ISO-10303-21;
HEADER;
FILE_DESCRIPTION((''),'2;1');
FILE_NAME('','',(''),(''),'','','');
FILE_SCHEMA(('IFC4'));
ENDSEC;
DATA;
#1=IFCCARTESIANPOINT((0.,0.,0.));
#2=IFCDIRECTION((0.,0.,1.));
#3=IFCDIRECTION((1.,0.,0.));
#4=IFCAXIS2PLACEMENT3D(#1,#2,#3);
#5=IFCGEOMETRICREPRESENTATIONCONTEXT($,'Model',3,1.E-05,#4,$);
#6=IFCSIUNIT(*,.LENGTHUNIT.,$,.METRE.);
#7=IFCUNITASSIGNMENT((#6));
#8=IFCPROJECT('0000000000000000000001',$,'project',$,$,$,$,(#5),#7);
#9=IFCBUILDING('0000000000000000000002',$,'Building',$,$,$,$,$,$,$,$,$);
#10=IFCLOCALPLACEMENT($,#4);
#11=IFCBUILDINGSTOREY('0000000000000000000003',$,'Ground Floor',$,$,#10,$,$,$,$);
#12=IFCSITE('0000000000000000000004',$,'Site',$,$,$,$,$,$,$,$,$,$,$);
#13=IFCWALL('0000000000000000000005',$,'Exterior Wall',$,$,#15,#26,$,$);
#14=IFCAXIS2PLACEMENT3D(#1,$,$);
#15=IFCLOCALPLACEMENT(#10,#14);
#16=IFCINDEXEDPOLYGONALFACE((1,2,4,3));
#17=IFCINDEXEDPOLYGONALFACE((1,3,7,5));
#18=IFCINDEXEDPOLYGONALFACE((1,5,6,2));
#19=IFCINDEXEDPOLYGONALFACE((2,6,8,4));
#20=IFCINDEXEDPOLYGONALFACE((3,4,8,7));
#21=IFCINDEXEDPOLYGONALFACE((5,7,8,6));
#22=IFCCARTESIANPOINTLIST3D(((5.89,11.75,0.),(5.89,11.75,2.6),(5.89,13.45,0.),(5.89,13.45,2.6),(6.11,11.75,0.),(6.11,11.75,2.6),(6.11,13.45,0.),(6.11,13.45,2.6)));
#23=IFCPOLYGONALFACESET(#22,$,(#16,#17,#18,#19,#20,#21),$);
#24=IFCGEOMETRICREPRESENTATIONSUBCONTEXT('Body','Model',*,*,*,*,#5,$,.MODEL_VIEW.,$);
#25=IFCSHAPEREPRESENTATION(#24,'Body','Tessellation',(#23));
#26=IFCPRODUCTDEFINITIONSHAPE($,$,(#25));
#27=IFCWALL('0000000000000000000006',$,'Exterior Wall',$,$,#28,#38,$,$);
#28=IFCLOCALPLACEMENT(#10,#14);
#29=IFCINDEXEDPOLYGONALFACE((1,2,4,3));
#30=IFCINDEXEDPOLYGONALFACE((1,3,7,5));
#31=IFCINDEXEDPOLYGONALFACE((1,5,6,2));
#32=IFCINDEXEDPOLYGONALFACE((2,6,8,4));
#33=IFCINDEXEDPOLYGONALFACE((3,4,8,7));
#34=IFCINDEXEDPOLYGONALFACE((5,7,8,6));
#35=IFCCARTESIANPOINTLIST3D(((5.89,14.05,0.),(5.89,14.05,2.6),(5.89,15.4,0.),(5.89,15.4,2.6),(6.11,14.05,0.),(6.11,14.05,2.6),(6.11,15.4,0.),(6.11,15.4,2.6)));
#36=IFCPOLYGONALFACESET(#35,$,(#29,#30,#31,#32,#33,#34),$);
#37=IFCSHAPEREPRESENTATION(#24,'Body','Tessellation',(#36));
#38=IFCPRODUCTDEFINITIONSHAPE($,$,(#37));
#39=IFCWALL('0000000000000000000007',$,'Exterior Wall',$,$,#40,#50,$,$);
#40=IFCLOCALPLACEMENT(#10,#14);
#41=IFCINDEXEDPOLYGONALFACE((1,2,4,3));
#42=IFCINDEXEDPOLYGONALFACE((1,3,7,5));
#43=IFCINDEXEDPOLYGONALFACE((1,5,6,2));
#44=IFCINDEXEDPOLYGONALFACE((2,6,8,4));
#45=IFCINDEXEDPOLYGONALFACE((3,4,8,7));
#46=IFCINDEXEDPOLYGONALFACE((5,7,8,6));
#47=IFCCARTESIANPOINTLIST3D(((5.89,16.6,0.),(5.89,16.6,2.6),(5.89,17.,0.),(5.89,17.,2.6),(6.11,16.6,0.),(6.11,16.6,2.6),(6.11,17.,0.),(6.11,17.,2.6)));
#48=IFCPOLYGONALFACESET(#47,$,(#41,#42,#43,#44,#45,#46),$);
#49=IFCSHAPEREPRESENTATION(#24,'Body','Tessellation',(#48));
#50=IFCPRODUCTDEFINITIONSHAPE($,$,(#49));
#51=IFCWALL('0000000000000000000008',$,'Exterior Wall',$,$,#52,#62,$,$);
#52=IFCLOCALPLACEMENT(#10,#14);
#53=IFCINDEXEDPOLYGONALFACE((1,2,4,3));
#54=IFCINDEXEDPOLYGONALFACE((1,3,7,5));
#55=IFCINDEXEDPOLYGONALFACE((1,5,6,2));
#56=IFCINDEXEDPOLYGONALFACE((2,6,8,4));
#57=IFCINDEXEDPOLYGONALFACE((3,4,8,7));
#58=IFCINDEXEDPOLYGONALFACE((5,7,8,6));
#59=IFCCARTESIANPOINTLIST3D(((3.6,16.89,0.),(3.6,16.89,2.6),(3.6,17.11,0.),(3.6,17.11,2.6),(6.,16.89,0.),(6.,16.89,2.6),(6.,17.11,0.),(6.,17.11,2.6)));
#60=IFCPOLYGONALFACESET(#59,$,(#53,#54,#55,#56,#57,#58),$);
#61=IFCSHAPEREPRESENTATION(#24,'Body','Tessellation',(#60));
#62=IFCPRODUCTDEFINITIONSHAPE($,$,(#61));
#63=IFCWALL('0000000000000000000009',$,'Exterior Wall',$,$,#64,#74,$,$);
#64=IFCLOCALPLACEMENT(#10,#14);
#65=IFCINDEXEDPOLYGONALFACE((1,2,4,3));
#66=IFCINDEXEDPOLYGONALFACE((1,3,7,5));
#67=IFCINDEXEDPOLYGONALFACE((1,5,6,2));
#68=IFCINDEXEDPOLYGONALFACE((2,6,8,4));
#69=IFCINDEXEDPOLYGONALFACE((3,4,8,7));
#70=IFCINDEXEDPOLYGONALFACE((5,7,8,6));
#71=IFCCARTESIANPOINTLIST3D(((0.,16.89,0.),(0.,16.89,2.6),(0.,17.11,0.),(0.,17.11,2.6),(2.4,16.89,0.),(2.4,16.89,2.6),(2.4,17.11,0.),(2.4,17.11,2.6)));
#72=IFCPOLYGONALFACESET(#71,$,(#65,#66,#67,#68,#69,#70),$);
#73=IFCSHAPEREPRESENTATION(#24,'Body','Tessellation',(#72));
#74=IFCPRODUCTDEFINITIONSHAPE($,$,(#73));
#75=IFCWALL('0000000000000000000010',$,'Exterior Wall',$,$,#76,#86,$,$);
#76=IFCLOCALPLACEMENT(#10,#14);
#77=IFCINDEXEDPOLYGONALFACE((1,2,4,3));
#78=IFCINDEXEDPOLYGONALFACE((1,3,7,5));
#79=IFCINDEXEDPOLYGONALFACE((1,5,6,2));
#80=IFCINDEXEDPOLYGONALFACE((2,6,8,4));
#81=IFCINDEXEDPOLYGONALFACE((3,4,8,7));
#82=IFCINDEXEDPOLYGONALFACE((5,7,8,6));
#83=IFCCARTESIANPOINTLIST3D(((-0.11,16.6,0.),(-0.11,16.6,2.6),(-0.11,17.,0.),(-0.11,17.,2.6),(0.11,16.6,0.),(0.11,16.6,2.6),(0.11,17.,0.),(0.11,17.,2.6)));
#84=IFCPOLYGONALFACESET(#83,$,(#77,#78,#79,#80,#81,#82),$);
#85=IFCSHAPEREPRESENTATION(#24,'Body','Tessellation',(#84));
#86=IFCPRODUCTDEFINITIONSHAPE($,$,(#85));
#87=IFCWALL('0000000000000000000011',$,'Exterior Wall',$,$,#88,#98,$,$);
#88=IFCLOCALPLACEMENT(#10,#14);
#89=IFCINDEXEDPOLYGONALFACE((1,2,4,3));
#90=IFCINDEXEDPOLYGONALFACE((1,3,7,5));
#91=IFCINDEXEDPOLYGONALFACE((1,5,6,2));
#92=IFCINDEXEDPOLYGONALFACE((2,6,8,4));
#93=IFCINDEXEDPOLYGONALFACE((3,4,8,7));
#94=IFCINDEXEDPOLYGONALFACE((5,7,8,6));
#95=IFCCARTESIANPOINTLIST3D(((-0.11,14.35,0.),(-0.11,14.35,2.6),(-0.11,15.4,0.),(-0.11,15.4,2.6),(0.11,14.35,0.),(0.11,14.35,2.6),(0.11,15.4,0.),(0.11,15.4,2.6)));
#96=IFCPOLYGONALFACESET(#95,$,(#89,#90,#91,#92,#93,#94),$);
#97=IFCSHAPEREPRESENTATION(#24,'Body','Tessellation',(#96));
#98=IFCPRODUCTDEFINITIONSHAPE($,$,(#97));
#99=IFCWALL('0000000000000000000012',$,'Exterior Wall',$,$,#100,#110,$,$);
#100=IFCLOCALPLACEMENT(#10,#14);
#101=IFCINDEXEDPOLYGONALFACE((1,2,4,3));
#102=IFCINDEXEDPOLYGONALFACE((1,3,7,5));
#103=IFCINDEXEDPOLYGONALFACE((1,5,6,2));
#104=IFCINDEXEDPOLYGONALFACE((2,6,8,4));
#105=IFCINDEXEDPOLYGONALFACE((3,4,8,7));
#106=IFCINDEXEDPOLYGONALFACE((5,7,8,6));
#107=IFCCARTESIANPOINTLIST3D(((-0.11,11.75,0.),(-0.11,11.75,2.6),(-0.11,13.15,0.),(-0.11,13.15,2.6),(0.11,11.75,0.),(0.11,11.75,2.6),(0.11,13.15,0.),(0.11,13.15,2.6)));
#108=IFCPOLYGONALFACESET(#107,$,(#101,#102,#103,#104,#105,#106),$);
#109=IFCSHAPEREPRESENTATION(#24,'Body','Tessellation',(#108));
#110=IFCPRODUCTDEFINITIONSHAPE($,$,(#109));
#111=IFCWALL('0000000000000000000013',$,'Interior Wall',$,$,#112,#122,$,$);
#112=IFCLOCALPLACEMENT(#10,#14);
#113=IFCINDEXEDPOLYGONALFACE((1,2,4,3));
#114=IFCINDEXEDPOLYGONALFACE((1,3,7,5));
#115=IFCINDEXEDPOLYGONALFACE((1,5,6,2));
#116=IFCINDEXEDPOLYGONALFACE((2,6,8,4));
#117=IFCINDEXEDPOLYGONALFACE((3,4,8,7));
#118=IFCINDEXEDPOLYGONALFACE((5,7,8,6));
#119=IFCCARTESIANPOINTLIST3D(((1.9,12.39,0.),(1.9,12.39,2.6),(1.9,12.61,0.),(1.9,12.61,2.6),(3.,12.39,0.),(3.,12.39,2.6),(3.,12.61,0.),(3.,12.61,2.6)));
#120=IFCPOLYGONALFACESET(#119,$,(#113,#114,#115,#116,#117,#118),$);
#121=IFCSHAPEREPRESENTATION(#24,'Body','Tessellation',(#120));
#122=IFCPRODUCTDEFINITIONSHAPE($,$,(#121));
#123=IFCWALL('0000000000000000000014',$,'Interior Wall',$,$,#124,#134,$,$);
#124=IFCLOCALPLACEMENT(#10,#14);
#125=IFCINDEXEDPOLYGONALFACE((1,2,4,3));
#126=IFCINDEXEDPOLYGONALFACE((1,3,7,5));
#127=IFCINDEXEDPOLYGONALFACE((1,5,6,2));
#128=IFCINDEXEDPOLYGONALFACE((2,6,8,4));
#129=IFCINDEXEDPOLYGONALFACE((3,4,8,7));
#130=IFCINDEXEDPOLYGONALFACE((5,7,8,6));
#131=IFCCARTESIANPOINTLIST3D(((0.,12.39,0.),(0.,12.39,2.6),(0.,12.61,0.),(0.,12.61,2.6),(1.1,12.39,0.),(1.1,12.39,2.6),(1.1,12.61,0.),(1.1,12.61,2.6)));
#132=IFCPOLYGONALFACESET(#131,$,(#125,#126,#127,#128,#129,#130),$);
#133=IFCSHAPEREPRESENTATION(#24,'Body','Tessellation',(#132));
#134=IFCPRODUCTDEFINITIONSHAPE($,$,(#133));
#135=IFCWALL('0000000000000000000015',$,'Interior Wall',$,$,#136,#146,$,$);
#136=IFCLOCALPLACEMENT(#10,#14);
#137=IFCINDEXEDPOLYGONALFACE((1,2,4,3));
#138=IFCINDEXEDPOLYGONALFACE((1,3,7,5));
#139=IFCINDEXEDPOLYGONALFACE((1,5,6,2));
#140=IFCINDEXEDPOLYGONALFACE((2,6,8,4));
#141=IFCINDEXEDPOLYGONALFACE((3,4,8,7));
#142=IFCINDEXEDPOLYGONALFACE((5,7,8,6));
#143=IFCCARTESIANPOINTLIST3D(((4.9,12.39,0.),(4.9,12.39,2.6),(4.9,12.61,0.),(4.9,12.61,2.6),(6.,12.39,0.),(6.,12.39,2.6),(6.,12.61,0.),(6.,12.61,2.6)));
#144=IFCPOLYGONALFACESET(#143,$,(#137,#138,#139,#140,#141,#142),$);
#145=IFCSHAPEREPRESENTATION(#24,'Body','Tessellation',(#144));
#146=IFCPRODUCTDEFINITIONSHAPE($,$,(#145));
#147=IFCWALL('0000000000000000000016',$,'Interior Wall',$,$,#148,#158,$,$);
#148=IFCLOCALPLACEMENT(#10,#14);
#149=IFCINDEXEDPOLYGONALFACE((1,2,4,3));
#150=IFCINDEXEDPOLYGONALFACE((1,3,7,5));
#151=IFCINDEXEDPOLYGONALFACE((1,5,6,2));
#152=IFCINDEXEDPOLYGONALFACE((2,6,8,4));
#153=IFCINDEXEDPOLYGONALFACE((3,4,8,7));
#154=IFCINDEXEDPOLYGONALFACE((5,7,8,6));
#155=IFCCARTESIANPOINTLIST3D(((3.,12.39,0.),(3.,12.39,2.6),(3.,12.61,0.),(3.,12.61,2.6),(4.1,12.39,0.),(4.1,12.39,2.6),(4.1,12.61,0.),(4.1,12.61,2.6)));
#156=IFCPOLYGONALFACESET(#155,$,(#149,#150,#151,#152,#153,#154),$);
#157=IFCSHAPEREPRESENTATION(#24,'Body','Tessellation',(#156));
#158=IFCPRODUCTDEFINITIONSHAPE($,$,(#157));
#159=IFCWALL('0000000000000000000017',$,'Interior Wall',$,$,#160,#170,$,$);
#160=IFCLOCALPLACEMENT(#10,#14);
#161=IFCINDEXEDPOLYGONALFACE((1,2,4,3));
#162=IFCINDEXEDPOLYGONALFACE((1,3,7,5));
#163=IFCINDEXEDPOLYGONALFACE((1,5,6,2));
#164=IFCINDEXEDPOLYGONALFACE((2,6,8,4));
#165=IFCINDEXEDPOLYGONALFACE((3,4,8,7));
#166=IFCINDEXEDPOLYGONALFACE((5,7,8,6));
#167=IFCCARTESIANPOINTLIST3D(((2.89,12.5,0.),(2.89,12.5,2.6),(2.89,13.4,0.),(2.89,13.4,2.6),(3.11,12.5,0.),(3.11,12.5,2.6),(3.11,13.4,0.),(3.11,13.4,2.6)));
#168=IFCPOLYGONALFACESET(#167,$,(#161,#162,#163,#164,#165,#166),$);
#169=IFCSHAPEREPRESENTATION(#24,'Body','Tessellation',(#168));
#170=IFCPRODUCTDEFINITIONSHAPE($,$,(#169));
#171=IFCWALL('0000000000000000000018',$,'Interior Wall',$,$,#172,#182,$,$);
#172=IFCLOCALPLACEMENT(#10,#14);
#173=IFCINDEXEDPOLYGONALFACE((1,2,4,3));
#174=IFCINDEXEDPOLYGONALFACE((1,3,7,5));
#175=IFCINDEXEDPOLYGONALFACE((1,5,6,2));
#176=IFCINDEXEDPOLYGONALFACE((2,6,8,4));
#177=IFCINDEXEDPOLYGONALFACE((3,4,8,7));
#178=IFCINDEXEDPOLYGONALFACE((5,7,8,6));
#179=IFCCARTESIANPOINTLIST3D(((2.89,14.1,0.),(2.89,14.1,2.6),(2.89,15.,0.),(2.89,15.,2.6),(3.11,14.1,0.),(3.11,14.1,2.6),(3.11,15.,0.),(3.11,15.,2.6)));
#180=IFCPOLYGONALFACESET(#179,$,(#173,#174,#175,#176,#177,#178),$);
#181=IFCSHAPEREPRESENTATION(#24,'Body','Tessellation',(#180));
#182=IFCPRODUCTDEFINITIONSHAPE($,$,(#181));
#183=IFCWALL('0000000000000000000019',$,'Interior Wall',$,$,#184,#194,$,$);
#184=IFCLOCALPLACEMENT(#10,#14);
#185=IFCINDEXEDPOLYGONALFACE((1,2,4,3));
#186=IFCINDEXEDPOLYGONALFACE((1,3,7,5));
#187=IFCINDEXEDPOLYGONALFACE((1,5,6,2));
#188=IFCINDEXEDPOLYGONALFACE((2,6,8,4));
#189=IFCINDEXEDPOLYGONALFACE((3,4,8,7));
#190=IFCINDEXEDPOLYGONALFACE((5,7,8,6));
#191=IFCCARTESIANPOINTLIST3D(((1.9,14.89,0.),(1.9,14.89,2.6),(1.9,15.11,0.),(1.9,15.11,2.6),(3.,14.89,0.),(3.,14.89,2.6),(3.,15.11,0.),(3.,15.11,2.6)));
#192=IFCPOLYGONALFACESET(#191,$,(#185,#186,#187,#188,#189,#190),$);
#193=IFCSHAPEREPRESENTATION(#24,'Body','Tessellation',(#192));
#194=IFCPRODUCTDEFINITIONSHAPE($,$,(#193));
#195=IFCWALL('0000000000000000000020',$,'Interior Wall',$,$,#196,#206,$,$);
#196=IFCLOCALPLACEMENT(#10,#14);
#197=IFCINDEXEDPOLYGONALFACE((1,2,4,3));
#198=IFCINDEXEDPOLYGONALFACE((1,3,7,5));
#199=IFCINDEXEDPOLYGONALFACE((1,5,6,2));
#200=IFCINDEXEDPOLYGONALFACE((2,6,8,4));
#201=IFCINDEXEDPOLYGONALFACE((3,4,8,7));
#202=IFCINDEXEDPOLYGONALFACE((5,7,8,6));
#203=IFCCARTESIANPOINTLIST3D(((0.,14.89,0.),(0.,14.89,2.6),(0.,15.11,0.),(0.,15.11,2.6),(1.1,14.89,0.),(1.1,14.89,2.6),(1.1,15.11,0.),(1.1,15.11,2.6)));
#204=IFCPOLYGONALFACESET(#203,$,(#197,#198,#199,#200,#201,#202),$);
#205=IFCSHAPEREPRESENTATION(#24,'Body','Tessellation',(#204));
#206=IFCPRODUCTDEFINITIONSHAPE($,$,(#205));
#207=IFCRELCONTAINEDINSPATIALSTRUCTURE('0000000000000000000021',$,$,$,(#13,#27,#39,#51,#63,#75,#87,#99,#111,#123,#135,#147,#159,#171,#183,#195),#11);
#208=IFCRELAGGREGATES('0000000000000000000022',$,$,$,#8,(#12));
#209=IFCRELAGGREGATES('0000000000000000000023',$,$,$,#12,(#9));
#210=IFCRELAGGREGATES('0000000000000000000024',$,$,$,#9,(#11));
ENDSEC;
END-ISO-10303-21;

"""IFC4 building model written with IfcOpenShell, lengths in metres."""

from ifc_helpers import new_model, si_unit, frame, origin_with_axes, place, context, subcontext, project, spatial, indexed_curve, outline, extrude, element, save


model = new_model("IFC4")

# Units and contexts
model_context = context("Model", 3, precision=1e-05, world=origin_with_axes())
body_context = subcontext(model_context, "Body", "Model", "MODEL_VIEW")
ifc_project = project(units=[si_unit("LENGTHUNIT", "METRE")], contexts=[model_context])

# Site, building, storey
site = spatial("IfcSite", under=ifc_project, Name="Site")
building = spatial("IfcBuilding", under=site, Name="Building")
storey_placement = place(None, origin_with_axes())
storey = spatial("IfcBuildingStorey", under=building, at=storey_placement, Name="Ground Floor")

# Walls
wall_1_placement = place(storey_placement, frame((6.0, 11.75, 0.0), z_axis=(0.0, 0.0, 1.0), x_axis=(0.0, 1.0, 0.0)))
element("IfcWall", 1, at=wall_1_placement, inside=storey, Name="Exterior Wall", context=body_context, shape_type="SweptSolid", body=[
    extrude(outline(indexed_curve([(0.0, 0.0), (0.0, 0.22), (1.7, 0.22), (1.7, 0.0), (0.0, 0.0)], self_intersect=False)), frame((0.0, -0.11, 0.0), z_axis=(0.0, 0.0, 1.0), x_axis=(1.0, 0.0, 0.0)), (0.0, 0.0, 1.0), 2.6),
])
wall_2_placement = place(storey_placement, frame((6.0, 14.05, 0.0), z_axis=(0.0, 0.0, 1.0), x_axis=(0.0, 1.0, 0.0)))
element("IfcWall", 2, at=wall_2_placement, inside=storey, Name="Exterior Wall", context=body_context, shape_type="SweptSolid", body=[
    extrude(outline(indexed_curve([(0.0, 0.0), (0.0, 0.22), (1.35, 0.22), (1.35, 0.0), (0.0, 0.0)], self_intersect=False)), frame((0.0, -0.11, 0.0), z_axis=(0.0, 0.0, 1.0), x_axis=(1.0, 0.0, 0.0)), (0.0, 0.0, 1.0), 2.6),
])
wall_3_placement = place(storey_placement, frame((6.0, 16.6, 0.0), z_axis=(0.0, 0.0, 1.0), x_axis=(0.0, 1.0, 0.0)))
element("IfcWall", 3, at=wall_3_placement, inside=storey, Name="Exterior Wall", context=body_context, shape_type="SweptSolid", body=[
    extrude(outline(indexed_curve([(0.0, 0.0), (0.0, 0.22), (0.4, 0.22), (0.4, 0.0), (0.0, 0.0)], self_intersect=False)), frame((0.0, -0.11, 0.0), z_axis=(0.0, 0.0, 1.0), x_axis=(1.0, 0.0, 0.0)), (0.0, 0.0, 1.0), 2.6),
])
for number, where, z_axis, x_axis, name in (
    (4, (6.0, 17.0, 0.0), (0.0, 0.0, 1.0), (-1.0, 0.0, 0.0), "Exterior Wall"),
    (5, (2.4, 17.0, 0.0), (0.0, 0.0, 1.0), (-1.0, 0.0, 0.0), "Exterior Wall"),
):
    element("IfcWall", number, at=place(storey_placement, frame(where, z_axis=z_axis, x_axis=x_axis)), inside=storey, Name=name, context=body_context, shape_type="SweptSolid", body=[
        extrude(outline(indexed_curve([(0.0, 0.0), (0.0, 0.22), (2.4, 0.22), (2.4, 0.0), (0.0, 0.0)], self_intersect=False)), frame((0.0, -0.11, 0.0), z_axis=(0.0, 0.0, 1.0), x_axis=(1.0, 0.0, 0.0)), (0.0, 0.0, 1.0), 2.6),
    ])
wall_4_placement = place(storey_placement, frame((0.0, 17.0, 0.0), z_axis=(0.0, 0.0, 1.0), x_axis=(0.0, -1.0, 0.0)))
element("IfcWall", 6, at=wall_4_placement, inside=storey, Name="Exterior Wall", context=body_context, shape_type="SweptSolid", body=[
    extrude(outline(indexed_curve([(0.0, 0.0), (0.0, 0.22), (0.4, 0.22), (0.4, 0.0), (0.0, 0.0)], self_intersect=False)), frame((0.0, -0.11, 0.0), z_axis=(0.0, 0.0, 1.0), x_axis=(1.0, 0.0, 0.0)), (0.0, 0.0, 1.0), 2.6),
])
wall_5_placement = place(storey_placement, frame((0.0, 15.4, 0.0), z_axis=(0.0, 0.0, 1.0), x_axis=(0.0, -1.0, 0.0)))
element("IfcWall", 7, at=wall_5_placement, inside=storey, Name="Exterior Wall", context=body_context, shape_type="SweptSolid", body=[
    extrude(outline(indexed_curve([(0.0, 0.0), (0.0, 0.22), (1.05, 0.22), (1.05, 0.0), (0.0, 0.0)], self_intersect=False)), frame((0.0, -0.11, 0.0), z_axis=(0.0, 0.0, 1.0), x_axis=(1.0, 0.0, 0.0)), (0.0, 0.0, 1.0), 2.6),
])
wall_6_placement = place(storey_placement, frame((0.0, 13.15, 0.0), z_axis=(0.0, 0.0, 1.0), x_axis=(0.0, -1.0, 0.0)))
element("IfcWall", 8, at=wall_6_placement, inside=storey, Name="Exterior Wall", context=body_context, shape_type="SweptSolid", body=[
    extrude(outline(indexed_curve([(0.0, 0.0), (0.0, 0.22), (1.4, 0.22), (1.4, 0.0), (0.0, 0.0)], self_intersect=False)), frame((0.0, -0.11, 0.0), z_axis=(0.0, 0.0, 1.0), x_axis=(1.0, 0.0, 0.0)), (0.0, 0.0, 1.0), 2.6),
])
for number, where, z_axis, x_axis, name in (
    (9, (3.0, 12.5, 0.0), (0.0, 0.0, 1.0), (-1.0, 0.0, 0.0), "Interior Wall"),
    (10, (1.1, 12.5, 0.0), (0.0, 0.0, 1.0), (-1.0, 0.0, 0.0), "Interior Wall"),
):
    element("IfcWall", number, at=place(storey_placement, frame(where, z_axis=z_axis, x_axis=x_axis)), inside=storey, Name=name, context=body_context, shape_type="SweptSolid", body=[
        extrude(outline(indexed_curve([(0.0, 0.0), (0.0, 0.22), (1.1, 0.22), (1.1, 0.0), (0.0, 0.0)], self_intersect=False)), frame((0.0, -0.11, 0.0), z_axis=(0.0, 0.0, 1.0), x_axis=(1.0, 0.0, 0.0)), (0.0, 0.0, 1.0), 2.6),
    ])
for number, where, z_axis, x_axis, name in (
    (11, (6.0, 12.5, 0.0), (0.0, 0.0, 1.0), (-1.0, 0.0, 0.0), "Interior Wall"),
    (12, (4.1, 12.5, 0.0), (0.0, 0.0, 1.0), (-1.0, 0.0, 0.0), "Interior Wall"),
):
    element("IfcWall", number, at=place(storey_placement, frame(where, z_axis=z_axis, x_axis=x_axis)), inside=storey, Name=name, context=body_context, shape_type="SweptSolid", body=[
        extrude(outline(indexed_curve([(0.0, 0.0), (0.0, 0.22), (1.1, 0.22), (1.1, 0.0), (0.0, 0.0)], self_intersect=False)), frame((0.0, -0.11, 0.0), z_axis=(0.0, 0.0, 1.0), x_axis=(1.0, 0.0, 0.0)), (0.0, 0.0, 1.0), 2.6),
    ])
for number, where, z_axis, x_axis, name in (
    (13, (3.0, 12.5, 0.0), (0.0, 0.0, 1.0), (0.0, 1.0, 0.0), "Interior Wall"),
    (14, (3.0, 14.1, 0.0), (0.0, 0.0, 1.0), (0.0, 1.0, 0.0), "Interior Wall"),
):
    element("IfcWall", number, at=place(storey_placement, frame(where, z_axis=z_axis, x_axis=x_axis)), inside=storey, Name=name, context=body_context, shape_type="SweptSolid", body=[
        extrude(outline(indexed_curve([(0.0, 0.0), (0.0, 0.22), (0.9, 0.22), (0.9, 0.0), (0.0, 0.0)], self_intersect=False)), frame((0.0, -0.11, 0.0), z_axis=(0.0, 0.0, 1.0), x_axis=(1.0, 0.0, 0.0)), (0.0, 0.0, 1.0), 2.6),
    ])
for number, where, z_axis, x_axis, name in (
    (15, (3.0, 15.0, 0.0), (0.0, 0.0, 1.0), (-1.0, 0.0, 0.0), "Interior Wall"),
    (16, (1.1, 15.0, 0.0), (0.0, 0.0, 1.0), (-1.0, 0.0, 0.0), "Interior Wall"),
):
    element("IfcWall", number, at=place(storey_placement, frame(where, z_axis=z_axis, x_axis=x_axis)), inside=storey, Name=name, context=body_context, shape_type="SweptSolid", body=[
        extrude(outline(indexed_curve([(0.0, 0.0), (0.0, 0.22), (1.1, 0.22), (1.1, 0.0), (0.0, 0.0)], self_intersect=False)), frame((0.0, -0.11, 0.0), z_axis=(0.0, 0.0, 1.0), x_axis=(1.0, 0.0, 0.0)), (0.0, 0.0, 1.0), 2.6),
    ])

save(model, "model.ifc")
